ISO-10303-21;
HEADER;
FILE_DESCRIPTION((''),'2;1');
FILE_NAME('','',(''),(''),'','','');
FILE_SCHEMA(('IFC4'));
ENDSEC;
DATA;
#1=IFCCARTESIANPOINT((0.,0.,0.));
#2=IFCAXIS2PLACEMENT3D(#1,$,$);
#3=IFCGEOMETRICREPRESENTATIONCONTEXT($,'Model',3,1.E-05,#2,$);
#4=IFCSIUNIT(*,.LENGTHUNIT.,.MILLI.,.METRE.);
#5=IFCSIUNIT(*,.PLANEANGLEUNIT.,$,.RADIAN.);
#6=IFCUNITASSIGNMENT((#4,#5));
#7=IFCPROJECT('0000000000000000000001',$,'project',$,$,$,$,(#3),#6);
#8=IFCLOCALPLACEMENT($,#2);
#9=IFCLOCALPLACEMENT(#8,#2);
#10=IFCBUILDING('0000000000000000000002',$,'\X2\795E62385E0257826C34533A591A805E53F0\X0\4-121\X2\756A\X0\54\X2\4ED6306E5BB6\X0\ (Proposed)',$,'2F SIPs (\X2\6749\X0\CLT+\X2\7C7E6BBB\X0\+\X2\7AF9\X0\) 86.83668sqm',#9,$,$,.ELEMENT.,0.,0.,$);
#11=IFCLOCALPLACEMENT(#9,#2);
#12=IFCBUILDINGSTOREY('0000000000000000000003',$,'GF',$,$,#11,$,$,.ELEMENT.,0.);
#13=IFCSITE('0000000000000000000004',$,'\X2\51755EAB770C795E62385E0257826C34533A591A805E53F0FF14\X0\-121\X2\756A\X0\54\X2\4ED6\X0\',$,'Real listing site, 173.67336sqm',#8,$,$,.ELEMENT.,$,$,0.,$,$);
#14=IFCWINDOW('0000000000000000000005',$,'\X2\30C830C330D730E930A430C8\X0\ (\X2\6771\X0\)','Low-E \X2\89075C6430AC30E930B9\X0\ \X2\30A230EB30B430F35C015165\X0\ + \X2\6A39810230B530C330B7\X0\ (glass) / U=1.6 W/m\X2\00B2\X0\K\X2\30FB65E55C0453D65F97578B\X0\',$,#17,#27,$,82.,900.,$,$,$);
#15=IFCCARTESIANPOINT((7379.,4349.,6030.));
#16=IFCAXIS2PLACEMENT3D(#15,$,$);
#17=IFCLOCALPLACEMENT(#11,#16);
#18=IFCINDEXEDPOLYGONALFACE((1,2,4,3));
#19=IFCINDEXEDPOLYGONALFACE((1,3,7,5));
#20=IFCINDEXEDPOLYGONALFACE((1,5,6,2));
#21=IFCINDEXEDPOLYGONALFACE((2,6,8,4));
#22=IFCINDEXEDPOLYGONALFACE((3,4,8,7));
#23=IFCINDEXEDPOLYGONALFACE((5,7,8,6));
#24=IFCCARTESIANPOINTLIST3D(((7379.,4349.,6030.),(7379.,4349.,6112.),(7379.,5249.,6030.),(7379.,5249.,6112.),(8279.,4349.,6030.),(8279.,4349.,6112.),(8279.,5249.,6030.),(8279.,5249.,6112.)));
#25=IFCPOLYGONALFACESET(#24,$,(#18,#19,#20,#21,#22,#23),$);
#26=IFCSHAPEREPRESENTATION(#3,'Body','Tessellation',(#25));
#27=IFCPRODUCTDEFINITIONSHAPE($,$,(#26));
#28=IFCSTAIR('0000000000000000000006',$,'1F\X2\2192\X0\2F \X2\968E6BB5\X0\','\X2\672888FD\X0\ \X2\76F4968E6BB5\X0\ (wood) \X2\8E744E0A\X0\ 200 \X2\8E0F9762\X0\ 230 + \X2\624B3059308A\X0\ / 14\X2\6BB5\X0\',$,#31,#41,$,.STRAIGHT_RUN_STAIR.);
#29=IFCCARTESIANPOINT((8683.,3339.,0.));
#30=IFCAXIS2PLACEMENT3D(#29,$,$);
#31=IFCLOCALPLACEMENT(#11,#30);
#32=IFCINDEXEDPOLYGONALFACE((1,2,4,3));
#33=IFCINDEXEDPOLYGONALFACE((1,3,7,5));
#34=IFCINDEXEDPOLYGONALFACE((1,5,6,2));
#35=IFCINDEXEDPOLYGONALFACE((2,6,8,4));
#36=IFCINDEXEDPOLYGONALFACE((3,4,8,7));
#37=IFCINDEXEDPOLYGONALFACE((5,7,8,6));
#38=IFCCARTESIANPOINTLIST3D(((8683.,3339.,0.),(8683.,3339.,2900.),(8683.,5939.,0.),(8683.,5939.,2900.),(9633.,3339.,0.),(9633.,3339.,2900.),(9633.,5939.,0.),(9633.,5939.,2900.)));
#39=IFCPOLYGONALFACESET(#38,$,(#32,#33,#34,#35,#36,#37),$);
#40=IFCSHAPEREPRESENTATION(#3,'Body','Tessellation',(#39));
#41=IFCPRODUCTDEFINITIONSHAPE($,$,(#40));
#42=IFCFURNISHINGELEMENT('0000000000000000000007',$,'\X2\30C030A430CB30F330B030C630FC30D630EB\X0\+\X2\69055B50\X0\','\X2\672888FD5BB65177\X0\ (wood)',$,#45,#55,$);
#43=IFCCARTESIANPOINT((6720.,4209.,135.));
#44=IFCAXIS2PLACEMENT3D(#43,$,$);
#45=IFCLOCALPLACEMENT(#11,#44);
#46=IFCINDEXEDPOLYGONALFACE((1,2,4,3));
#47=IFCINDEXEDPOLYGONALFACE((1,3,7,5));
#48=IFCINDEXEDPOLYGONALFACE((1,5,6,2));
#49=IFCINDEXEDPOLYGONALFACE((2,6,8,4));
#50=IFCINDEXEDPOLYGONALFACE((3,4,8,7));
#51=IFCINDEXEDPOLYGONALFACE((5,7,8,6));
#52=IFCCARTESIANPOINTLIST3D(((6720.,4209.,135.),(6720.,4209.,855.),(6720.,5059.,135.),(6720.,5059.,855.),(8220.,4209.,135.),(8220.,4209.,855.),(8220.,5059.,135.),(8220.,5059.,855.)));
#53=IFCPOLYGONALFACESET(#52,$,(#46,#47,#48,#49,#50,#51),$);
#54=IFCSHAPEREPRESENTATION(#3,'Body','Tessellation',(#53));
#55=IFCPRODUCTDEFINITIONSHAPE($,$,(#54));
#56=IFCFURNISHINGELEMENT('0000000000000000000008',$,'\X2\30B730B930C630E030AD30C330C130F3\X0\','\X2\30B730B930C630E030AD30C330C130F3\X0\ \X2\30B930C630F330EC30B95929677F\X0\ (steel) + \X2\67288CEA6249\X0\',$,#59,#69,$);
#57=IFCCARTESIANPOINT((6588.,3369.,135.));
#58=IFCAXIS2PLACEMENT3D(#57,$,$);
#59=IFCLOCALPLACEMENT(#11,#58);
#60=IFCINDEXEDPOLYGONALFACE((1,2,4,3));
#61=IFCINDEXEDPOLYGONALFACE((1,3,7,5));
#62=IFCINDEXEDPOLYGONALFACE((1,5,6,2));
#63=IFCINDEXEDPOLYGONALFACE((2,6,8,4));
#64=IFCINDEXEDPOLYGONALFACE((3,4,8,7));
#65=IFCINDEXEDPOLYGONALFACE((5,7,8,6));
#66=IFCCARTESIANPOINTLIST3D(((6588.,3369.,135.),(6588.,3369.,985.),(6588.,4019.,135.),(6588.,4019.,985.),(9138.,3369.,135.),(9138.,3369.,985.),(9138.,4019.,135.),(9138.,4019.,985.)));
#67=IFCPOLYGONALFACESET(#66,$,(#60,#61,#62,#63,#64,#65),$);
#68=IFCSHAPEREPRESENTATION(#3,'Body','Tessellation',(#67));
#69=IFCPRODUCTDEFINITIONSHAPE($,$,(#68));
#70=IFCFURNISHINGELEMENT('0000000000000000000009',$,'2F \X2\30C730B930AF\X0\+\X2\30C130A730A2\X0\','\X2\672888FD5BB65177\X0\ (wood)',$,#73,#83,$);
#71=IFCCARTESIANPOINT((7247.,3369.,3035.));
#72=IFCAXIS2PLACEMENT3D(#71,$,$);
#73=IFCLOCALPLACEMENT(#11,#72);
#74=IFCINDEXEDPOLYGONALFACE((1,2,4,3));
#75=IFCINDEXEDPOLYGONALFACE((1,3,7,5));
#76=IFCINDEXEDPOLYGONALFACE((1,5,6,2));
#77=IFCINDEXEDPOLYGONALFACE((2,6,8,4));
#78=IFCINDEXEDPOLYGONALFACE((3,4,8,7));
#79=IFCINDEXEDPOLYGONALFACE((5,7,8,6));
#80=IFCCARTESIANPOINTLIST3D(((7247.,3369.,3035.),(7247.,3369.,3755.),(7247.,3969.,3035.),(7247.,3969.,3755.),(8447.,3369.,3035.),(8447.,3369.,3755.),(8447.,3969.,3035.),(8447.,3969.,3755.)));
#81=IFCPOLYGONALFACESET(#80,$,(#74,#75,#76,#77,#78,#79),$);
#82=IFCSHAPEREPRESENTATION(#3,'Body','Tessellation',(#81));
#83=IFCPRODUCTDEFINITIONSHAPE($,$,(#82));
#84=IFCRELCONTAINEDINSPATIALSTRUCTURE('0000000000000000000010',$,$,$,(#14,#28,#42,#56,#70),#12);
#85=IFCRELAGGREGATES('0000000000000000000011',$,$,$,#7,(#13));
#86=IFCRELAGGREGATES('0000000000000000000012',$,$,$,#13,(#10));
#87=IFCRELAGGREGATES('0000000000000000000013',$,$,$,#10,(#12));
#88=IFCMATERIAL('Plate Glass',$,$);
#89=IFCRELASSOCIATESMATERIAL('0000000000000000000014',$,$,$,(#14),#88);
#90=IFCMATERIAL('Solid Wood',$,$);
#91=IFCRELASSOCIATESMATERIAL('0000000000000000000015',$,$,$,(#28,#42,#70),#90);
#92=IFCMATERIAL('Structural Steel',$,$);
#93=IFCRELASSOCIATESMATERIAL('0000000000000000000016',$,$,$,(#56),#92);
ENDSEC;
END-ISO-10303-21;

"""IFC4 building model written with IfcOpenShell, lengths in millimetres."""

from ifc_helpers import new_model, si_unit, frame, frame_2d, origin, place, context, project, spatial, rectangle, extrude, material, element, save


model = new_model("IFC4")

# Units and contexts
model_context = context("Model", 3, precision=1e-05, world=origin())
ifc_project = project(units=[si_unit("LENGTHUNIT", "METRE", prefix="MILLI"), si_unit("PLANEANGLEUNIT", "RADIAN")], contexts=[model_context])

# Site, building, storey
site_placement = place(None, origin())
site = spatial("IfcSite", under=ifc_project, at=site_placement, Name="兵庫県神戸市垂水区多聞台４-121番54他", ObjectType="Real listing site, 173.67336sqm", CompositionType="ELEMENT", RefElevation=0.0)
building_placement = place(site_placement, origin())
building = spatial("IfcBuilding", under=site, at=building_placement, Name="神戸市垂水区多聞台4-121番54他の家 (Proposed)", ObjectType="2F SIPs (杉CLT+籾殻+竹) 86.83668sqm", CompositionType="ELEMENT", ElevationOfRefHeight=0.0, ElevationOfTerrain=0.0)
storey_placement = place(building_placement, origin())
storey = spatial("IfcBuildingStorey", under=building, at=storey_placement, Name="GF", CompositionType="ELEMENT", Elevation=0.0)

# Shared definitions
ifc_material_1 = material(Name="Solid Wood")

# Shared definitions
ifc_material_2 = material(Name="Plate Glass")

# Window
window_1_placement = place(storey_placement, frame((7379.0, 4349.0, 6030.0)))
element("IfcWindow", 1, at=window_1_placement, inside=storey, material=ifc_material_2, Name="トップライト (東)", Description="Low-E 複層ガラス アルゴン封入 + 樹脂サッシ (glass) / U=1.6 W/m²K・日射取得型", OverallHeight=82.0, OverallWidth=900.0, context=model_context, shape_type="SweptSolid", body=[
    extrude(rectangle(XDim=900.0, YDim=900.0, at=frame_2d((450.0, 450.0))), frame((7379.0, 4349.0, 6030.0)), (0.0, 0.0, 1.0), 82.0),
])

# Stair
stair_placement = place(storey_placement, frame((8683.0, 3339.0, 0.0)))
element("IfcStair", 2, at=stair_placement, inside=storey, material=ifc_material_1, Name="1F→2F 階段", Description="木製 直階段 (wood) 蹴上 200 踏面 230 + 手すり / 14段", PredefinedType="STRAIGHT_RUN_STAIR", context=model_context, shape_type="SweptSolid", body=[
    extrude(rectangle(XDim=950.0, YDim=2600.0, at=frame_2d((475.0, 1300.0))), frame((8683.0, 3339.0, 0.0)), (0.0, 0.0, 1.0), 2900.0),
])

# Furnishing elements
furnishing_1_placement = place(storey_placement, frame((6720.0, 4209.0, 135.0)))
element("IfcFurnishingElement", 3, at=furnishing_1_placement, inside=storey, material=ifc_material_1, Name="ダイニングテーブル+椅子", Description="木製家具 (wood)", context=model_context, shape_type="SweptSolid", body=[
    extrude(rectangle(XDim=1500.0, YDim=850.0, at=frame_2d((750.0, 425.0))), frame((6720.0, 4209.0, 135.0)), (0.0, 0.0, 1.0), 720.0),
])
ifc_material_3 = material(Name="Structural Steel")
furnishing_2_placement = place(storey_placement, frame((6588.0, 3369.0, 135.0)))
element("IfcFurnishingElement", 4, at=furnishing_2_placement, inside=storey, material=ifc_material_3, Name="システムキッチン", Description="システムキッチン ステンレス天板 (steel) + 木質扉", context=model_context, shape_type="SweptSolid", body=[
    extrude(rectangle(XDim=2550.0, YDim=650.0, at=frame_2d((1275.0, 325.0))), frame((6588.0, 3369.0, 135.0)), (0.0, 0.0, 1.0), 850.0),
])
furnishing_3_placement = place(storey_placement, frame((7247.0, 3369.0, 3035.0)))
element("IfcFurnishingElement", 5, at=furnishing_3_placement, inside=storey, material=ifc_material_1, Name="2F デスク+チェア", Description="木製家具 (wood)", context=model_context, shape_type="SweptSolid", body=[
    extrude(rectangle(XDim=1200.0, YDim=600.0, at=frame_2d((600.0, 300.0))), frame((7247.0, 3369.0, 3035.0)), (0.0, 0.0, 1.0), 720.0),
])

save(model, "model.ifc")
